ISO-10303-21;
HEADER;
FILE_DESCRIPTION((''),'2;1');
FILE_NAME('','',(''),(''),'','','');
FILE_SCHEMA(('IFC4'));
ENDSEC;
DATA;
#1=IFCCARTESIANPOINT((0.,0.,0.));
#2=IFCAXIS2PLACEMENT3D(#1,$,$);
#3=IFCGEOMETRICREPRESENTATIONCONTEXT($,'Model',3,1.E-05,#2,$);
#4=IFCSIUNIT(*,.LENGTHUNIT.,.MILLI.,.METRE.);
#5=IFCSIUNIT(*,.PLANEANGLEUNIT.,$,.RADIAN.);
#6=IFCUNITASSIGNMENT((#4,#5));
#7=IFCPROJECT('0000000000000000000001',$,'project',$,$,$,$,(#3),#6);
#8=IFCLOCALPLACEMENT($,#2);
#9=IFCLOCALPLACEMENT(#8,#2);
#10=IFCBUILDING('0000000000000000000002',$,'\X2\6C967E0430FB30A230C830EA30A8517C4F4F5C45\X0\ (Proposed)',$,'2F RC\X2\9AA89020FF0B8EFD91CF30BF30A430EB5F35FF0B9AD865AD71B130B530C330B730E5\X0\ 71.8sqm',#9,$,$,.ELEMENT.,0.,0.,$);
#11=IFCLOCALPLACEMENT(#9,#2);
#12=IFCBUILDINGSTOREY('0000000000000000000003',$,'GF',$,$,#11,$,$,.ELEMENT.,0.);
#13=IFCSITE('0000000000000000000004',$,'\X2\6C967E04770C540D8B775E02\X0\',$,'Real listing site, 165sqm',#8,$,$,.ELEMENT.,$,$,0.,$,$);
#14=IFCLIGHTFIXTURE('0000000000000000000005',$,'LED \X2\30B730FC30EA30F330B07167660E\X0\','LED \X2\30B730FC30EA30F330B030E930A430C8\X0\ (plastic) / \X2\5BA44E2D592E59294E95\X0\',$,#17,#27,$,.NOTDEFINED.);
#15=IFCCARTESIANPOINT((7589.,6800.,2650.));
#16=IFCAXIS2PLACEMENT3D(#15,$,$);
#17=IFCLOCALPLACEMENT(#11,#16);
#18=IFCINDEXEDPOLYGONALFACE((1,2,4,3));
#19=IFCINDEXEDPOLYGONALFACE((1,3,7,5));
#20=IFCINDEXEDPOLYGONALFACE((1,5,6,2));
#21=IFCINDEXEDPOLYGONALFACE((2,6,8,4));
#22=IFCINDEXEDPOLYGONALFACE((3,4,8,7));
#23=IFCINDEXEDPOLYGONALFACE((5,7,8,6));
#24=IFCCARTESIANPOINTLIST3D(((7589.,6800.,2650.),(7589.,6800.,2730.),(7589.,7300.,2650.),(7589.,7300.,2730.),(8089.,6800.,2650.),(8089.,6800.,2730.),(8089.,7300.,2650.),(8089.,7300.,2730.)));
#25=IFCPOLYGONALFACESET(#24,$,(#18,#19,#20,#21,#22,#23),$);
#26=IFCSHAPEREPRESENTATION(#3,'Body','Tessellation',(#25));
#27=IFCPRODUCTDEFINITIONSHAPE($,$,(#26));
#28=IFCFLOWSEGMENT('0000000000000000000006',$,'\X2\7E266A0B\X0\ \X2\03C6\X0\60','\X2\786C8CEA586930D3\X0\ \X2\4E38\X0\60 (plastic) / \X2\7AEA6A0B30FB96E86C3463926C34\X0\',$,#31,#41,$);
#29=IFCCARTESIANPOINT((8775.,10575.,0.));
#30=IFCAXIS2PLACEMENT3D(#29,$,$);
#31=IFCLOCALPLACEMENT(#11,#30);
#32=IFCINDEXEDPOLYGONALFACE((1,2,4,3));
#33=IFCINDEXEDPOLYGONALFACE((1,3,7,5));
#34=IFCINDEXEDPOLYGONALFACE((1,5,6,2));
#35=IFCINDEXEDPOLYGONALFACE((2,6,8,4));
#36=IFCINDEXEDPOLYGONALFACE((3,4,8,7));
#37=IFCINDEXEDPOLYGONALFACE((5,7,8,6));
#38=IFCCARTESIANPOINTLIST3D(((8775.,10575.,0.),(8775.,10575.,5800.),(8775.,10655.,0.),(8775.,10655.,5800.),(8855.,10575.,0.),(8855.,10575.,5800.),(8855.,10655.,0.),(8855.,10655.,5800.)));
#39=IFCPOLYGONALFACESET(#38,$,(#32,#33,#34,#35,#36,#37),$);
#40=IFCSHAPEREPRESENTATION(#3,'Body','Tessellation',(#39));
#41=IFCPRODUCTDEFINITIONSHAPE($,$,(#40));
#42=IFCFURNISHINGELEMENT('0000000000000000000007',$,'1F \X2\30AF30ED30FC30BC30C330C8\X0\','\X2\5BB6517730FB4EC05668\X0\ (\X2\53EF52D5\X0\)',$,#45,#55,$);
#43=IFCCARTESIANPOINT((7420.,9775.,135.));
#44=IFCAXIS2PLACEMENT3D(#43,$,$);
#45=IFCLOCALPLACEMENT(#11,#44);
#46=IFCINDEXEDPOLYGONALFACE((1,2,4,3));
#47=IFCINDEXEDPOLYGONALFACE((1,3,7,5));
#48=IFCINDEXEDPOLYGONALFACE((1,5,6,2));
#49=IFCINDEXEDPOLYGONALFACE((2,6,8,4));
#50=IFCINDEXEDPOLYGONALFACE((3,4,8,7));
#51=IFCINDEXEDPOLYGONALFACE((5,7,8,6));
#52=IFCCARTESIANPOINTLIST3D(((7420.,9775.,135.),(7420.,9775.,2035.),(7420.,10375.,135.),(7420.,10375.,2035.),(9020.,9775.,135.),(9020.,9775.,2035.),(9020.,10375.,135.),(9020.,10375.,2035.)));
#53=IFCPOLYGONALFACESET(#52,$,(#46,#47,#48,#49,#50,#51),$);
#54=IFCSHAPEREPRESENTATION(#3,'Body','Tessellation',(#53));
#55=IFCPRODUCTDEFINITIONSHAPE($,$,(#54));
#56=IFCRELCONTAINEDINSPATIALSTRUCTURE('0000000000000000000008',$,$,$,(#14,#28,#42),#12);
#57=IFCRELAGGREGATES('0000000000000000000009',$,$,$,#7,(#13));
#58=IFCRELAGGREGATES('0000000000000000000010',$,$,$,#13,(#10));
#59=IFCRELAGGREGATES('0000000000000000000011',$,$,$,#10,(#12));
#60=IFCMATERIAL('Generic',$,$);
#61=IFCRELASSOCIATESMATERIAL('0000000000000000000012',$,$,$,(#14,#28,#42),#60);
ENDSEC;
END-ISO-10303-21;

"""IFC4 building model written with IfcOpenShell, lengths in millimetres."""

from ifc_helpers import new_model, si_unit, frame, frame_2d, origin, place, context, project, spatial, rectangle, extrude, material, element, save


model = new_model("IFC4")

# Units and contexts
model_context = context("Model", 3, precision=1e-05, world=origin())
ifc_project = project(units=[si_unit("LENGTHUNIT", "METRE", prefix="MILLI"), si_unit("PLANEANGLEUNIT", "RADIAN")], contexts=[model_context])

# Site, building, storey
site_placement = place(None, origin())
site = spatial("IfcSite", under=ifc_project, at=site_placement, Name="沖縄県名護市", ObjectType="Real listing site, 165sqm", CompositionType="ELEMENT", RefElevation=0.0)
building_placement = place(site_placement, origin())
building = spatial("IfcBuilding", under=site, at=building_placement, Name="沖縄・アトリエ兼住居 (Proposed)", ObjectType="2F RC骨造＋軽量タイル張＋高断熱サッシュ 71.8sqm", CompositionType="ELEMENT", ElevationOfRefHeight=0.0, ElevationOfTerrain=0.0)
storey_placement = place(building_placement, origin())
storey = spatial("IfcBuildingStorey", under=building, at=storey_placement, Name="GF", CompositionType="ELEMENT", Elevation=0.0)

# Shared definitions
ifc_material_1 = material(Name="Generic")

# Light fixture
light_fixture_placement = place(storey_placement, frame((7589.0, 6800.0, 2650.0)))
element("IfcLightFixture", 1, at=light_fixture_placement, inside=storey, material=ifc_material_1, Name="LED シーリング照明", Description="LED シーリングライト (plastic) / 室中央天井", PredefinedType="NOTDEFINED", context=model_context, shape_type="SweptSolid", body=[
    extrude(rectangle(XDim=500.0, YDim=500.0, at=frame_2d((250.0, 250.0))), frame((7589.0, 6800.0, 2650.0)), (0.0, 0.0, 1.0), 80.0),
])

# Flow segment
flow_segment_placement = place(storey_placement, frame((8775.0, 10575.0, 0.0)))
element("IfcFlowSegment", 2, at=flow_segment_placement, inside=storey, material=ifc_material_1, Name="縦樋 φ60", Description="硬質塩ビ 丸60 (plastic) / 竪樋・雨水排水", context=model_context, shape_type="SweptSolid", body=[
    extrude(rectangle(XDim=80.0, YDim=80.0, at=frame_2d((40.0, 40.0))), frame((8775.0, 10575.0, 0.0)), (0.0, 0.0, 1.0), 5800.0),
])

# Furnishing element
furnishing_placement = place(storey_placement, frame((7420.0, 9775.0, 135.0)))
element("IfcFurnishingElement", 3, at=furnishing_placement, inside=storey, material=ifc_material_1, Name="1F クローゼット", Description="家具・什器 (可動)", context=model_context, shape_type="SweptSolid", body=[
    extrude(rectangle(XDim=1600.0, YDim=600.0, at=frame_2d((800.0, 300.0))), frame((7420.0, 9775.0, 135.0)), (0.0, 0.0, 1.0), 1900.0),
])

save(model, "model.ifc")
